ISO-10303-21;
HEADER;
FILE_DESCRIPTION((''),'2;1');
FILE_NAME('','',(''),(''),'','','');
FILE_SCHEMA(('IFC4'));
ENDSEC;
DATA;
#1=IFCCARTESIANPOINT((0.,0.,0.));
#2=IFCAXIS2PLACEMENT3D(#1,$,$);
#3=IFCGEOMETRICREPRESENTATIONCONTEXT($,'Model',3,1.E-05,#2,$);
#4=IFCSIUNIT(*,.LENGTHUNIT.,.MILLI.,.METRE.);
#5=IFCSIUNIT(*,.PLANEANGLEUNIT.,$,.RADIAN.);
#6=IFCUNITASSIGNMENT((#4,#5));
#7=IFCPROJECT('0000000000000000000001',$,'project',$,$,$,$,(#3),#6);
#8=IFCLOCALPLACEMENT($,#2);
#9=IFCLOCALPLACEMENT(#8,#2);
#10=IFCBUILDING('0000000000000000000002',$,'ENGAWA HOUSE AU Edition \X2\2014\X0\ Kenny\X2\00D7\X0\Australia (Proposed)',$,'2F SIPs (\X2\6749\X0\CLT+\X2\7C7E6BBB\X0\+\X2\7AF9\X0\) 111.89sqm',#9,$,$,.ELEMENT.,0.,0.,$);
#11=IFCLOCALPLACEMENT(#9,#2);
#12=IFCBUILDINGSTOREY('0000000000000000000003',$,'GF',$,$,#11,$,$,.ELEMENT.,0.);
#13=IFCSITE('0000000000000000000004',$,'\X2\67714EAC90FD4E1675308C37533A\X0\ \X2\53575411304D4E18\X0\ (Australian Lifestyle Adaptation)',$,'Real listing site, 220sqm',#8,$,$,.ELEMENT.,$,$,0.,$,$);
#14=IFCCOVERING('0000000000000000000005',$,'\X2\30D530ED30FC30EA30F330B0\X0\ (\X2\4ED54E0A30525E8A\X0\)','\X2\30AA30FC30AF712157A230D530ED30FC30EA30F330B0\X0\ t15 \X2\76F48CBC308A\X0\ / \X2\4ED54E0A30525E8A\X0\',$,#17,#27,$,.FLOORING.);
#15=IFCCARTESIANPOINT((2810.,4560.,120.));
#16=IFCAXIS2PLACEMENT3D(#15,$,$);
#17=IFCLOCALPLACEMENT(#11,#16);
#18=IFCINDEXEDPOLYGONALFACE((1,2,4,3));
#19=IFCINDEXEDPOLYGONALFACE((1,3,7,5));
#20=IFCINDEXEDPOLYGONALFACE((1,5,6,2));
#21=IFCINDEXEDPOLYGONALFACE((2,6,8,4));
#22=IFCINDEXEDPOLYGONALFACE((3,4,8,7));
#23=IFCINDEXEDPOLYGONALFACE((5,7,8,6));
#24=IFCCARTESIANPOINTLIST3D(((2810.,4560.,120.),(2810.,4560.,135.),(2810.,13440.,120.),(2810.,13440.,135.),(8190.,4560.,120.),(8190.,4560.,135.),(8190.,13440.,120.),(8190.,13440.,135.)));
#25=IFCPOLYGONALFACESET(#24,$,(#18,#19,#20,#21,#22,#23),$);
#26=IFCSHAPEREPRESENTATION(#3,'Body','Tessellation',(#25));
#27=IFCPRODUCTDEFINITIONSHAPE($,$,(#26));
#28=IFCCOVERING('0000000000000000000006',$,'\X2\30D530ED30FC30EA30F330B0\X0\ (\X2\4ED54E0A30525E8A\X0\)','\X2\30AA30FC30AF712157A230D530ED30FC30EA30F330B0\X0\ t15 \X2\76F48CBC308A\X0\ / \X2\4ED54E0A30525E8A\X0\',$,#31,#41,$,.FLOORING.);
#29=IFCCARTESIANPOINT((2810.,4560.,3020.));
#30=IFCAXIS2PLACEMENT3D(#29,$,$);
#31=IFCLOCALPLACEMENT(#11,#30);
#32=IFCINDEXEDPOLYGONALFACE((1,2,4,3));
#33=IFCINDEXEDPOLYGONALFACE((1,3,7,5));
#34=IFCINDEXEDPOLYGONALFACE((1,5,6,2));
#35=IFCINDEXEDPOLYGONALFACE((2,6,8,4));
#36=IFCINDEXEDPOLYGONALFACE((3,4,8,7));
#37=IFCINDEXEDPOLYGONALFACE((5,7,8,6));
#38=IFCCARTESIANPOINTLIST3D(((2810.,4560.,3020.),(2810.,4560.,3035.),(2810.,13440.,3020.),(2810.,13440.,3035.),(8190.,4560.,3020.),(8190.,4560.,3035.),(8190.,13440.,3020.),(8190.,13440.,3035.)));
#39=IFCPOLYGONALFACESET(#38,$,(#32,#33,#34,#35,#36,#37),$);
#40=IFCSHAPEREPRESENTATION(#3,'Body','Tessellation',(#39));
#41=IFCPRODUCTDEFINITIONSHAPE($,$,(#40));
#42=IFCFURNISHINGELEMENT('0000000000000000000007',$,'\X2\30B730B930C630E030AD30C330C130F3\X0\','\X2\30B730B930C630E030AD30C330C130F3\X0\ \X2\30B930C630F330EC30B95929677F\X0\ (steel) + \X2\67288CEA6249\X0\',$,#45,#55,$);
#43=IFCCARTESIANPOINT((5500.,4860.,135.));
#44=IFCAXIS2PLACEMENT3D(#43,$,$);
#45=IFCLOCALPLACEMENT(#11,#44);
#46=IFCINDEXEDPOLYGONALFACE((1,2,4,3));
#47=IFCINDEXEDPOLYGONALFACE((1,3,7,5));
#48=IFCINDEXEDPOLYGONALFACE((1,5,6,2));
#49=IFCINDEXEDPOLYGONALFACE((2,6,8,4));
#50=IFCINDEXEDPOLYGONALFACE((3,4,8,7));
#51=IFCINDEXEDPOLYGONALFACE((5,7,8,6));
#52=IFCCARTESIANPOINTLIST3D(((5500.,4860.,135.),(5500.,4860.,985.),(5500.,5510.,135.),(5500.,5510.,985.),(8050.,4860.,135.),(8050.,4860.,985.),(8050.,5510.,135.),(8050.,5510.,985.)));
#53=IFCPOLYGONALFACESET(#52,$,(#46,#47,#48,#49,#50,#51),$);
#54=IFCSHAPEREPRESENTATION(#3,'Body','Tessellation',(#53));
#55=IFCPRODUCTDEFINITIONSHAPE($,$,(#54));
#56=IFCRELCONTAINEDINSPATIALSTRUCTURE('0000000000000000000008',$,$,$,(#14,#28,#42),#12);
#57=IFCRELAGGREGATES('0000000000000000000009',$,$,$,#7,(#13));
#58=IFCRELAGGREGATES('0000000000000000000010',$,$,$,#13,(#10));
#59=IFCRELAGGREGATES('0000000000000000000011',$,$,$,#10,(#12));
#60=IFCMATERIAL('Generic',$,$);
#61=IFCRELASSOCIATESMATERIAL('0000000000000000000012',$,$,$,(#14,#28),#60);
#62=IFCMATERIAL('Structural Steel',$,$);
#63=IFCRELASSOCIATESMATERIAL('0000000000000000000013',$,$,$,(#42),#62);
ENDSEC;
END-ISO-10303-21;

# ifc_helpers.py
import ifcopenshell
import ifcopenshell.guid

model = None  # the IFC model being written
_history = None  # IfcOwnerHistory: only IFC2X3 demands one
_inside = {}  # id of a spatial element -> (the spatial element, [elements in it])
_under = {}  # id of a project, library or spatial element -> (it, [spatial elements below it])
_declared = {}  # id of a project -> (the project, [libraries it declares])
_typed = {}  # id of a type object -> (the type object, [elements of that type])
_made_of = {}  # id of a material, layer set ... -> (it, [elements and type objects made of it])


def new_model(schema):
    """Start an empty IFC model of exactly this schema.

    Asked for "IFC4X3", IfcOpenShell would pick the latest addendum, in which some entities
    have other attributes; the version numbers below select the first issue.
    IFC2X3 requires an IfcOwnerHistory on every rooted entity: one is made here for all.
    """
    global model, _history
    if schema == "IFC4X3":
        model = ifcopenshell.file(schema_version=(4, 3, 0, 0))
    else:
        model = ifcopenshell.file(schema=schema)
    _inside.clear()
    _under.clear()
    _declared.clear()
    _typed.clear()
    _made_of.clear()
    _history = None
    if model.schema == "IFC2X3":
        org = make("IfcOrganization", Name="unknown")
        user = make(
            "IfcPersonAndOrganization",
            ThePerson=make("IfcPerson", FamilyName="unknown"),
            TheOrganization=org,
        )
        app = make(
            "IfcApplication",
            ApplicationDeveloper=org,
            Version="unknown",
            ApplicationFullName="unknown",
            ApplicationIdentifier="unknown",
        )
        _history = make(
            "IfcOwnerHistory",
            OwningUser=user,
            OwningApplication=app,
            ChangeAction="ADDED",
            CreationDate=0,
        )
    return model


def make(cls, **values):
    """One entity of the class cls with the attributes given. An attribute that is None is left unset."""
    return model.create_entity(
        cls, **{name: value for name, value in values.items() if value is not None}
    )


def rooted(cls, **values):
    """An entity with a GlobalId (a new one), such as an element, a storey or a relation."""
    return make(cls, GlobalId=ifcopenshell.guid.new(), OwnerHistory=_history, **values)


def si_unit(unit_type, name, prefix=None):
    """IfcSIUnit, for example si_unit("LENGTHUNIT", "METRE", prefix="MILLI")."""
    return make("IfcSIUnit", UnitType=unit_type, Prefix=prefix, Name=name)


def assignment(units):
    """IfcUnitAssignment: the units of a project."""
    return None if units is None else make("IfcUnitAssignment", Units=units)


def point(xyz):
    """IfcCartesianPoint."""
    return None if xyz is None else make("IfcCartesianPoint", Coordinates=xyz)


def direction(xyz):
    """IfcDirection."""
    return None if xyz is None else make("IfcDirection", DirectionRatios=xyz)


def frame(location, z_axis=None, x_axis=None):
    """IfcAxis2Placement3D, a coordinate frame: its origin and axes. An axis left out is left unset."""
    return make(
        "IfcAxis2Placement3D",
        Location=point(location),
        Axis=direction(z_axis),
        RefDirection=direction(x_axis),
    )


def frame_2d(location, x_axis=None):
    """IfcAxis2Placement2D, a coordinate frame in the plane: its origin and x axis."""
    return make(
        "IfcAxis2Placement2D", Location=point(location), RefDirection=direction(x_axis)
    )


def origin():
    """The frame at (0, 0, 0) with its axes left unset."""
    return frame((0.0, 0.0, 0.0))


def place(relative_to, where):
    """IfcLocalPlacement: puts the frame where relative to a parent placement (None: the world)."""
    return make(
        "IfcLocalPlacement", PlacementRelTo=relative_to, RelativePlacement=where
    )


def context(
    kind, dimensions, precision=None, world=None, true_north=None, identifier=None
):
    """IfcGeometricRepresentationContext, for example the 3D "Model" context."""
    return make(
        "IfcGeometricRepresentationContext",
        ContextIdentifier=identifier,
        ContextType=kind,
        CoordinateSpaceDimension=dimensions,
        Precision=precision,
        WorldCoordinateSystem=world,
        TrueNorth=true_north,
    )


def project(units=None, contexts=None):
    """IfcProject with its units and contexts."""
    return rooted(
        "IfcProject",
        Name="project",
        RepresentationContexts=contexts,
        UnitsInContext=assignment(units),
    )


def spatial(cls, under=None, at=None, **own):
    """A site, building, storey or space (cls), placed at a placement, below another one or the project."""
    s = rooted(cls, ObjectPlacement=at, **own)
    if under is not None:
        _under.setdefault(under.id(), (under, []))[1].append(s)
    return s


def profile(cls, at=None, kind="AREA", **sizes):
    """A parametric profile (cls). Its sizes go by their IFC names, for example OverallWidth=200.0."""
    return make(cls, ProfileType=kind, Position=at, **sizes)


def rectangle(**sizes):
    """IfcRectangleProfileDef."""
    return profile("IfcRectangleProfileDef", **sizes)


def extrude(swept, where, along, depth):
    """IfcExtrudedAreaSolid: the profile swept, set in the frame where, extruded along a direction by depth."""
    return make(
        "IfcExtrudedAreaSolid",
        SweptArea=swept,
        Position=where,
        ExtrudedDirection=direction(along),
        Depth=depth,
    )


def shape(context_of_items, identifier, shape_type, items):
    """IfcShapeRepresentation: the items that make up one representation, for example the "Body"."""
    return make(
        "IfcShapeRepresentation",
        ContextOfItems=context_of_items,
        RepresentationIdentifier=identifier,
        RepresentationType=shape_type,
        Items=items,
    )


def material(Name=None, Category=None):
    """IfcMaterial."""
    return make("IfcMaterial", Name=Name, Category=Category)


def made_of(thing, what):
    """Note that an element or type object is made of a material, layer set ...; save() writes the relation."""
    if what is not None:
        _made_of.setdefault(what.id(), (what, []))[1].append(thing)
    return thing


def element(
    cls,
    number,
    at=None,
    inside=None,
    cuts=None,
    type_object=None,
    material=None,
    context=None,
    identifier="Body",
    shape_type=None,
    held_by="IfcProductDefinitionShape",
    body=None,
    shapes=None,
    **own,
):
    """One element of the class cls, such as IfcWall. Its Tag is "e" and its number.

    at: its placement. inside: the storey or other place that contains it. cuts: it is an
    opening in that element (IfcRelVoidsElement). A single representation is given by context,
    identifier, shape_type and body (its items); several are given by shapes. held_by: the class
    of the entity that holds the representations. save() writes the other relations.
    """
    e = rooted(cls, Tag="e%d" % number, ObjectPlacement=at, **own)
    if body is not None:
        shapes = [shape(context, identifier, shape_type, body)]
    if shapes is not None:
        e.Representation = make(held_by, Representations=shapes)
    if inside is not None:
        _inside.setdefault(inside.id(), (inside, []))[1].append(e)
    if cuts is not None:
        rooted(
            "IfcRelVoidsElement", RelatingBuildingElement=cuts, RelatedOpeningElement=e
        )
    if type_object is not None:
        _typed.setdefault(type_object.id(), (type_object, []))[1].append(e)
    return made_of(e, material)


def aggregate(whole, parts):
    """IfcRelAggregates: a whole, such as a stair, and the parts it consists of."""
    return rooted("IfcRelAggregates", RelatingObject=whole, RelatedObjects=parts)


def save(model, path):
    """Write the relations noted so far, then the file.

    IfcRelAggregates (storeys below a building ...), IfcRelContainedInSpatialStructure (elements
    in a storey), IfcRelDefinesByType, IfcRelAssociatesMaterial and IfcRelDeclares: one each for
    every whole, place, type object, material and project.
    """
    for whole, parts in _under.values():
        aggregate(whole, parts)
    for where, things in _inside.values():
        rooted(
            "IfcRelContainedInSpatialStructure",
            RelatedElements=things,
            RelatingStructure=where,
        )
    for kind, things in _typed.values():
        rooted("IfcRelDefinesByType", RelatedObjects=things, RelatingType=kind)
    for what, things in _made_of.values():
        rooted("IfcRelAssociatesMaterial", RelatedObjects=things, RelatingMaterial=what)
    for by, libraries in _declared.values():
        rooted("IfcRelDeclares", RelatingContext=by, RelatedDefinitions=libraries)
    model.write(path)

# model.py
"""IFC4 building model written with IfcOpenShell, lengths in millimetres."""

from ifc_helpers import new_model, si_unit, frame, frame_2d, origin, place, context, project, spatial, rectangle, extrude, material, element, save


model = new_model("IFC4")

# Units and contexts
model_context = context("Model", 3, precision=1e-05, world=origin())
ifc_project = project(units=[si_unit("LENGTHUNIT", "METRE", prefix="MILLI"), si_unit("PLANEANGLEUNIT", "RADIAN")], contexts=[model_context])

# Site, building, storey
site_placement = place(None, origin())
site = spatial("IfcSite", under=ifc_project, at=site_placement, Name="東京都世田谷区 南向き丘 (Australian Lifestyle Adaptation)", ObjectType="Real listing site, 220sqm", CompositionType="ELEMENT", RefElevation=0.0)
building_placement = place(site_placement, origin())
building = spatial("IfcBuilding", under=site, at=building_placement, Name="ENGAWA HOUSE AU Edition — Kenny×Australia (Proposed)", ObjectType="2F SIPs (杉CLT+籾殻+竹) 111.89sqm", CompositionType="ELEMENT", ElevationOfRefHeight=0.0, ElevationOfTerrain=0.0)
storey_placement = place(building_placement, origin())
storey = spatial("IfcBuildingStorey", under=building, at=storey_placement, Name="GF", CompositionType="ELEMENT", Elevation=0.0)

# Shared definitions
ifc_material_1 = material(Name="Generic")

# Shared definitions
ifc_material_2 = material(Name="Structural Steel")

# Coverings
covering_1_placement = place(storey_placement, frame((2810.0, 4560.0, 120.0)))
element("IfcCovering", 1, at=covering_1_placement, inside=storey, material=ifc_material_1, Name="フローリング (仕上げ床)", Description="オーク無垢フローリング t15 直貼り / 仕上げ床", PredefinedType="FLOORING", context=model_context, shape_type="SweptSolid", body=[
    extrude(rectangle(XDim=5380.0, YDim=8880.0, at=frame_2d((2690.0, 4440.0))), frame((2810.0, 4560.0, 120.0)), (0.0, 0.0, 1.0), 15.0),
])
covering_2_placement = place(storey_placement, frame((2810.0, 4560.0, 3020.0)))
element("IfcCovering", 2, at=covering_2_placement, inside=storey, material=ifc_material_1, Name="フローリング (仕上げ床)", Description="オーク無垢フローリング t15 直貼り / 仕上げ床", PredefinedType="FLOORING", context=model_context, shape_type="SweptSolid", body=[
    extrude(rectangle(XDim=5380.0, YDim=8880.0, at=frame_2d((2690.0, 4440.0))), frame((2810.0, 4560.0, 3020.0)), (0.0, 0.0, 1.0), 15.0),
])

# Furnishing element
furnishing_placement = place(storey_placement, frame((5500.0, 4860.0, 135.0)))
element("IfcFurnishingElement", 3, at=furnishing_placement, inside=storey, material=ifc_material_2, Name="システムキッチン", Description="システムキッチン ステンレス天板 (steel) + 木質扉", context=model_context, shape_type="SweptSolid", body=[
    extrude(rectangle(XDim=2550.0, YDim=650.0, at=frame_2d((1275.0, 325.0))), frame((5500.0, 4860.0, 135.0)), (0.0, 0.0, 1.0), 850.0),
])

save(model, "model.ifc")
